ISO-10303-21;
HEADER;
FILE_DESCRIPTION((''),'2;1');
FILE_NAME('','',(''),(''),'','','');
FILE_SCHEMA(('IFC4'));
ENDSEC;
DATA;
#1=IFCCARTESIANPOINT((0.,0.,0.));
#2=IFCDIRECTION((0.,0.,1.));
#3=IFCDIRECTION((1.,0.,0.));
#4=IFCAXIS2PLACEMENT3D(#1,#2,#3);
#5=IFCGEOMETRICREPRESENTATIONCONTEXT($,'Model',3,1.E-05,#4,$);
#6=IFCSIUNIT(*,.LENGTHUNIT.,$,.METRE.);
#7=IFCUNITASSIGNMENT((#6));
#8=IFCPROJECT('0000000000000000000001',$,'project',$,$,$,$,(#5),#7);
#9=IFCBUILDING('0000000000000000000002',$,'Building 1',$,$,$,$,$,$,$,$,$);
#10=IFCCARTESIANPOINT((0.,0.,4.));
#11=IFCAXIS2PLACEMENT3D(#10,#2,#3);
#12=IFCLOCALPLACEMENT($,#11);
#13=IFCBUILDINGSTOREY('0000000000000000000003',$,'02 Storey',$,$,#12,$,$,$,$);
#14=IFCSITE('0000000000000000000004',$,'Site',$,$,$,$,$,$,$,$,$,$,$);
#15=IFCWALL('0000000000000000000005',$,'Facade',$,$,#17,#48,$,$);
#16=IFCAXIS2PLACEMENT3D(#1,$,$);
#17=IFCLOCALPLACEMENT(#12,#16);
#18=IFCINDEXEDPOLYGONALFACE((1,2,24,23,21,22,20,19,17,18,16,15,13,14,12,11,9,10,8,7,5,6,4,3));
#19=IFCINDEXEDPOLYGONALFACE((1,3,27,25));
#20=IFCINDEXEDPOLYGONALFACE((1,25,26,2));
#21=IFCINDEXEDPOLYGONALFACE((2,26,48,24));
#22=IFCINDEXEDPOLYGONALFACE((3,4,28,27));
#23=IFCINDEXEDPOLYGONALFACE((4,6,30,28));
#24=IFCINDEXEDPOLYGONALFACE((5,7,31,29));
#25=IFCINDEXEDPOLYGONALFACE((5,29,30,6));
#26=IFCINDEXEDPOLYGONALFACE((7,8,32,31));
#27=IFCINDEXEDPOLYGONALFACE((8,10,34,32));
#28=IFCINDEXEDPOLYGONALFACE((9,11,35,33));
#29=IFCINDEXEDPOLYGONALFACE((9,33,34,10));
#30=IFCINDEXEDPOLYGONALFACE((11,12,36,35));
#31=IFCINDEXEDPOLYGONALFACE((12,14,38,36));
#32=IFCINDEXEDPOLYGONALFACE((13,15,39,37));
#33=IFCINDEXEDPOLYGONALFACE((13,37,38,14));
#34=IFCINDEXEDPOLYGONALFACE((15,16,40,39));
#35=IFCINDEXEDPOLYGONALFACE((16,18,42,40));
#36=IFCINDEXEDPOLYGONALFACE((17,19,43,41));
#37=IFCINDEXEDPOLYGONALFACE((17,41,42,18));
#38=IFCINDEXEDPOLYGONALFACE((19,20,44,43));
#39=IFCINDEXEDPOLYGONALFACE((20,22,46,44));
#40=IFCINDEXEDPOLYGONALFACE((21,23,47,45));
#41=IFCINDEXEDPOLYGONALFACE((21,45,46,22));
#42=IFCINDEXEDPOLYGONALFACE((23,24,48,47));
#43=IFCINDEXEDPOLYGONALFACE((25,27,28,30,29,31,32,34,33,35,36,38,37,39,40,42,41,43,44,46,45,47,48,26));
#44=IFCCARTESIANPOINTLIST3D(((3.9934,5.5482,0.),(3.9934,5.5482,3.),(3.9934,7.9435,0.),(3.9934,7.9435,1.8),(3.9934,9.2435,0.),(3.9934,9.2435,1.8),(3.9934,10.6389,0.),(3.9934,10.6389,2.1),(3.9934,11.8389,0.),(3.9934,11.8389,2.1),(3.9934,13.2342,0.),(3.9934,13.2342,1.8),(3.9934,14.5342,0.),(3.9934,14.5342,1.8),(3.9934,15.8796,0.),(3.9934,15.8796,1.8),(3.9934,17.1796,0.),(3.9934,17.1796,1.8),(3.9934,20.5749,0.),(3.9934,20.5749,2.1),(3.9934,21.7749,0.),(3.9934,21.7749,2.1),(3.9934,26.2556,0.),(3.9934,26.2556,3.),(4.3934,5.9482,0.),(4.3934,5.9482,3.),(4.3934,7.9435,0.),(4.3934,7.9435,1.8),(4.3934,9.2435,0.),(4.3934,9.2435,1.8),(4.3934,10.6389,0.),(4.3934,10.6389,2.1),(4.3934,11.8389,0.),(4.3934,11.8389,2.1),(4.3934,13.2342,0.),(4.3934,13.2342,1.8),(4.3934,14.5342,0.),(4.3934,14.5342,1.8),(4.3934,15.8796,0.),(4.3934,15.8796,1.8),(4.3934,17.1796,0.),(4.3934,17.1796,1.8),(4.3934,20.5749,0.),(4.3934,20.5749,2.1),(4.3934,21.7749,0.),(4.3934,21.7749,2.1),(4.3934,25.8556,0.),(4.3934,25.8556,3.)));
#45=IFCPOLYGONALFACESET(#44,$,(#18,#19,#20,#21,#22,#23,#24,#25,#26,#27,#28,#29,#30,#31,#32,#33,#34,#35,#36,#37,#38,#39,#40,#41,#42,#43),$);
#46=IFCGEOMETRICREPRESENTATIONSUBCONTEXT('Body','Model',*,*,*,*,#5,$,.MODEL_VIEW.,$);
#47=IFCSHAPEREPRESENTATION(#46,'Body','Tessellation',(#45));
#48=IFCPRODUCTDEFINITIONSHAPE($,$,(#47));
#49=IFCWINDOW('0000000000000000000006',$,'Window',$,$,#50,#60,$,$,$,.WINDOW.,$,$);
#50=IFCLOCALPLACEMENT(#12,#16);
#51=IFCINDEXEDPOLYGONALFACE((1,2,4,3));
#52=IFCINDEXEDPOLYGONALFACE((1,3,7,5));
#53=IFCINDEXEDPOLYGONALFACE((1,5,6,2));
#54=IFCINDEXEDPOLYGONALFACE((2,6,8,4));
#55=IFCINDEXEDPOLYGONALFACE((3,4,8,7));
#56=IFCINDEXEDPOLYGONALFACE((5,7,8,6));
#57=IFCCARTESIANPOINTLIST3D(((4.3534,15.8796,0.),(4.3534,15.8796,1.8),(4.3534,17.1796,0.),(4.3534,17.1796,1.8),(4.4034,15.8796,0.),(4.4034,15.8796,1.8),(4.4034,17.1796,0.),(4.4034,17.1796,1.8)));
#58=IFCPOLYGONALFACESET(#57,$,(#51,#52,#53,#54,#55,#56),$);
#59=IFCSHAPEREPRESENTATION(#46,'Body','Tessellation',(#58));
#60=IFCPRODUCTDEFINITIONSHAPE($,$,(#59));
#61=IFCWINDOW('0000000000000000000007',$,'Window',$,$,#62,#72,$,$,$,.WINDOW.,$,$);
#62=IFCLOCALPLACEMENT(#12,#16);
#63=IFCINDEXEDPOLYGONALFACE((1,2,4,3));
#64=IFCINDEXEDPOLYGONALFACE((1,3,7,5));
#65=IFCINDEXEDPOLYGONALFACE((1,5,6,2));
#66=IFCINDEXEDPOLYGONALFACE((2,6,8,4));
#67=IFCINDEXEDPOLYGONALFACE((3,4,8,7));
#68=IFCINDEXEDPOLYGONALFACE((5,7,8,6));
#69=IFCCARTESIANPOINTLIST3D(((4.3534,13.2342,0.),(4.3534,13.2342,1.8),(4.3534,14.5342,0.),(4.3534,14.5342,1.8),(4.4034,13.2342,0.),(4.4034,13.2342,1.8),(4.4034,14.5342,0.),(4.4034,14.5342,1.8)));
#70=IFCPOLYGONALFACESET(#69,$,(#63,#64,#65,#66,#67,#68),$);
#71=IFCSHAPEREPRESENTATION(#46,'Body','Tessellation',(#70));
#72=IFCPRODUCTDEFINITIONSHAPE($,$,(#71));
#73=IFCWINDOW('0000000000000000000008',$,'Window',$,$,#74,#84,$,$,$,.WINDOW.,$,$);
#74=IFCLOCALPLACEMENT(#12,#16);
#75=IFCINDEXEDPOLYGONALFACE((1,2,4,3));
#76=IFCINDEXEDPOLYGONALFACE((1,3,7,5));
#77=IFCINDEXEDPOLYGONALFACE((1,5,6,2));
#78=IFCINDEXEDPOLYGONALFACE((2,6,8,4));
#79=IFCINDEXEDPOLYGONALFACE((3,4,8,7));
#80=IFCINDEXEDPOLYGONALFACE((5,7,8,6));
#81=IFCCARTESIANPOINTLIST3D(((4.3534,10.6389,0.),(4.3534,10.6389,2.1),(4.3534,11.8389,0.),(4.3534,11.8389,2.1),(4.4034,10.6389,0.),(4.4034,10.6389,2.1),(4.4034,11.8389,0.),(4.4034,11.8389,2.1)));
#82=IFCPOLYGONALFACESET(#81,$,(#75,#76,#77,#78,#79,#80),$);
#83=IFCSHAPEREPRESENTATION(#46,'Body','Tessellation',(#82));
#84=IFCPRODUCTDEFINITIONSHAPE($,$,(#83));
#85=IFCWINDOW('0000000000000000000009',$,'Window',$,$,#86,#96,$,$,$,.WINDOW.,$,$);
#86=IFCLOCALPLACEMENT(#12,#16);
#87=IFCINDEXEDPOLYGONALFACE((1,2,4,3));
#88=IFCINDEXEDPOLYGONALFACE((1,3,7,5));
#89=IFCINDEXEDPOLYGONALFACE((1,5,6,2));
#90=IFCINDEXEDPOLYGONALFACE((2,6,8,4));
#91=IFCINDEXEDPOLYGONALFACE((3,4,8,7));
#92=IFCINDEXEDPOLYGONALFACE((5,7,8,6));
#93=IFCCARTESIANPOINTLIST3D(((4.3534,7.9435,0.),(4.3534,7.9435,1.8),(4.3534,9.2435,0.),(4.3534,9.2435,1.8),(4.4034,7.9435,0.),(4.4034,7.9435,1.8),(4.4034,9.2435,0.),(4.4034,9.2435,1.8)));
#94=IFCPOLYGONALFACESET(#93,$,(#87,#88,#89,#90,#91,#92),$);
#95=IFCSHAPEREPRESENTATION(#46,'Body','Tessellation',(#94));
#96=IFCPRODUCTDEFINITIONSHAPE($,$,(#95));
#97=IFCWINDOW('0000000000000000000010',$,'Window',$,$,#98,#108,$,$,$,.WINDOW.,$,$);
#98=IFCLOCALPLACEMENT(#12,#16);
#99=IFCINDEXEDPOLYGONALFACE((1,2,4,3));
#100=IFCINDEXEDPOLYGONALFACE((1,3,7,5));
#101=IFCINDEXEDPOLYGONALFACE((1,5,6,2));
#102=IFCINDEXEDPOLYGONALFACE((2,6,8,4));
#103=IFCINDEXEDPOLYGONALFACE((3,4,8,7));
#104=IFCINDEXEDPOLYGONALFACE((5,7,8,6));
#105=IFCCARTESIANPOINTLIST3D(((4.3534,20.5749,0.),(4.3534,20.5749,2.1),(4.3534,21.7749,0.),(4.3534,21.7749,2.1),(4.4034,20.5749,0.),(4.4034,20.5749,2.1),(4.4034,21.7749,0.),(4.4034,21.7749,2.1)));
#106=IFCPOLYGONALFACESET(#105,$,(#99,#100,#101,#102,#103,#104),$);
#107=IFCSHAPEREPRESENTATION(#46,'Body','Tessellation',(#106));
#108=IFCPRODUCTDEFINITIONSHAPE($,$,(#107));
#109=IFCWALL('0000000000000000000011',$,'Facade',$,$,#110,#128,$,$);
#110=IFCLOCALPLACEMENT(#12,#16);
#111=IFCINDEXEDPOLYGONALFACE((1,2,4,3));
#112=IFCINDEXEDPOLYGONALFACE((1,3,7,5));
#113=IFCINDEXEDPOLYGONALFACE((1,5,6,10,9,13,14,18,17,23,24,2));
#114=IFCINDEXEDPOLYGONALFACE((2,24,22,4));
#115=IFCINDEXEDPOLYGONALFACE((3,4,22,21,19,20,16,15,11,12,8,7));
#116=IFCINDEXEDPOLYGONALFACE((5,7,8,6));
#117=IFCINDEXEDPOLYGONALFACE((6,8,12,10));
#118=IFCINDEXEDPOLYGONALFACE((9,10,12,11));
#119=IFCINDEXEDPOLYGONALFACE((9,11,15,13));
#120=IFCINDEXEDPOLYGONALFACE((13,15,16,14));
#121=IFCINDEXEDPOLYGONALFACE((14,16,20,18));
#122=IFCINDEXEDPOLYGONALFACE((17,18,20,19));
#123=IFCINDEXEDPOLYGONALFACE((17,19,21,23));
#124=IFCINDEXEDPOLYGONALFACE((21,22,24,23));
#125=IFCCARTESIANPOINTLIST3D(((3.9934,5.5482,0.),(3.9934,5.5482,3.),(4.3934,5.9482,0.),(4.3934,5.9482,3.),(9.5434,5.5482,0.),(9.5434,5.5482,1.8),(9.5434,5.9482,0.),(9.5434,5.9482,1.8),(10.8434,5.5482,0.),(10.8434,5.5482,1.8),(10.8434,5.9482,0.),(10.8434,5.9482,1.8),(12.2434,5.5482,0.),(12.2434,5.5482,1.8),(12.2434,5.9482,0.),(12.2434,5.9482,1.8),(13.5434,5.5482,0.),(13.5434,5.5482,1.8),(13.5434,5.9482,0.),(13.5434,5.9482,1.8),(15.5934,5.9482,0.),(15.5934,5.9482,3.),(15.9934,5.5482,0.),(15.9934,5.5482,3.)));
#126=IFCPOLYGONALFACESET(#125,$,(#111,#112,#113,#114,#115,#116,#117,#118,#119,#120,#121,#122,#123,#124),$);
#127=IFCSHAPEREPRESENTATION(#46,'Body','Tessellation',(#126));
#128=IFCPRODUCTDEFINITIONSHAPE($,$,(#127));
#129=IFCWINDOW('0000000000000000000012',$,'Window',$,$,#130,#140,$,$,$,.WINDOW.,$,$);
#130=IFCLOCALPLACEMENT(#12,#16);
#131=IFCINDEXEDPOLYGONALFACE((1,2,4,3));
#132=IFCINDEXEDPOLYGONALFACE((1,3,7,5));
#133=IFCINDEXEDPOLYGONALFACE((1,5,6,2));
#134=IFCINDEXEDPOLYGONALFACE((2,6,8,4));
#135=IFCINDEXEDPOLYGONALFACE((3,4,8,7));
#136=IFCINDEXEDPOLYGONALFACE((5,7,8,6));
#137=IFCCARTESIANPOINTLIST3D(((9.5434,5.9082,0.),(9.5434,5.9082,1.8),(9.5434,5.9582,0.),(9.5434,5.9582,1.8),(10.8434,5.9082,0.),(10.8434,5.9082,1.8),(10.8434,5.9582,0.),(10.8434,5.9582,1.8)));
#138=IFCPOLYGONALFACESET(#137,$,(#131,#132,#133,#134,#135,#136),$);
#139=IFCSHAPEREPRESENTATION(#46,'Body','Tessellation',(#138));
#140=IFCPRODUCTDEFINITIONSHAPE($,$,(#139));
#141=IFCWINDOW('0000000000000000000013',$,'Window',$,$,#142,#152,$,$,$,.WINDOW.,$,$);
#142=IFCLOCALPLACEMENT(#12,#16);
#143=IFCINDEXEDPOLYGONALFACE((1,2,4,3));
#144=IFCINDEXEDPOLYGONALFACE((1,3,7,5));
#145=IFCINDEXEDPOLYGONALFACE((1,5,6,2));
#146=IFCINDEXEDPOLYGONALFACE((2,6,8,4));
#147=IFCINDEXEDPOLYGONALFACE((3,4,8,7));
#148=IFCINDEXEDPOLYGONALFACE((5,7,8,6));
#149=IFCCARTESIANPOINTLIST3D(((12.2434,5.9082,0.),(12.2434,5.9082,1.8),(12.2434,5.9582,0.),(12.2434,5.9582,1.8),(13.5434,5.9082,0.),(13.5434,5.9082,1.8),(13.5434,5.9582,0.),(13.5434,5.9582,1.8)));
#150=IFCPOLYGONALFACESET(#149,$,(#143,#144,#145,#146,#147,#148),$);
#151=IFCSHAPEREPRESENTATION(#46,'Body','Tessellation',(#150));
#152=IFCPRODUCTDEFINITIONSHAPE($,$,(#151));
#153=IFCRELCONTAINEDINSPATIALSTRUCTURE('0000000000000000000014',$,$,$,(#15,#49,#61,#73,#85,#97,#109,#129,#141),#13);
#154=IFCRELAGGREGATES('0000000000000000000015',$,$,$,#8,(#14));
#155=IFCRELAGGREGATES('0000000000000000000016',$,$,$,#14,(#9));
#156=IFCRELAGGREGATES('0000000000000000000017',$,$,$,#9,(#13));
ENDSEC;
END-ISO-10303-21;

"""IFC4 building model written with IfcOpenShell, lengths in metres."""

from ifc_helpers import new_model, si_unit, frame, origin_with_axes, place, context, subcontext, project, spatial, line, indexed_curve, outline, extrude, element, fill, save


model = new_model("IFC4")

# Units and contexts
model_context = context("Model", 3, precision=1e-05, world=origin_with_axes())
body_context = subcontext(model_context, "Body", "Model", "MODEL_VIEW")
ifc_project = project(units=[si_unit("LENGTHUNIT", "METRE")], contexts=[model_context])

# Site, building, storey
site = spatial("IfcSite", under=ifc_project, Name="Site")
building = spatial("IfcBuilding", under=site, Name="Building 1")
storey_placement = place(None, frame((0.0, 0.0, 4.0), z_axis=(0.0, 0.0, 1.0), x_axis=(1.0, 0.0, 0.0)))
storey = spatial("IfcBuildingStorey", under=building, at=storey_placement, Name="02 Storey")

# Walls, openings, windows
wall_1_placement = place(storey_placement, origin_with_axes())
wall_1 = element("IfcWall", 1, at=wall_1_placement, inside=storey, Name="Facade", context=body_context, shape_type="SweptSolid", body=[
    extrude(outline(indexed_curve([(4.3934, 25.8556), (4.3934, 5.9482), (3.9934, 5.5482), (3.9934, 26.2556)], segments=[line(1, 2), line(2, 3), line(3, 4)])), origin_with_axes(), (0.0, 0.0, 1.0), 3.0),
])
opening_1_placement = place(wall_1_placement, origin_with_axes())
opening_1 = element("IfcOpeningElement", 2, at=opening_1_placement, cuts=wall_1, context=body_context, shape_type="SweptSolid", body=[
    extrude(outline(indexed_curve([(3.9534, 17.1796), (4.4534, 17.1796), (4.4534, 15.8796), (3.9534, 15.8796)], segments=[line(1, 2), line(2, 3), line(3, 4)])), origin_with_axes(), (0.0, 0.0, 1.0), 1.8),
])
opening_2_placement = place(wall_1_placement, origin_with_axes())
opening_2 = element("IfcOpeningElement", 3, at=opening_2_placement, cuts=wall_1, context=body_context, shape_type="SweptSolid", body=[
    extrude(outline(indexed_curve([(3.9534, 14.5342), (4.4534, 14.5342), (4.4534, 13.2342), (3.9534, 13.2342)], segments=[line(1, 2), line(2, 3), line(3, 4)])), origin_with_axes(), (0.0, 0.0, 1.0), 1.8),
])
opening_3_placement = place(wall_1_placement, origin_with_axes())
opening_3 = element("IfcOpeningElement", 4, at=opening_3_placement, cuts=wall_1, context=body_context, shape_type="SweptSolid", body=[
    extrude(outline(indexed_curve([(3.9534, 11.8389), (4.4534, 11.8389), (4.4534, 10.6389), (3.9534, 10.6389)], segments=[line(1, 2), line(2, 3), line(3, 4)])), origin_with_axes(), (0.0, 0.0, 1.0), 2.1),
])
opening_4_placement = place(wall_1_placement, origin_with_axes())
opening_4 = element("IfcOpeningElement", 5, at=opening_4_placement, cuts=wall_1, context=body_context, shape_type="SweptSolid", body=[
    extrude(outline(indexed_curve([(3.9534, 9.2435), (4.4534, 9.2435), (4.4534, 7.9435), (3.9534, 7.9435)], segments=[line(1, 2), line(2, 3), line(3, 4)])), origin_with_axes(), (0.0, 0.0, 1.0), 1.8),
])
opening_5_placement = place(wall_1_placement, origin_with_axes())
opening_5 = element("IfcOpeningElement", 6, at=opening_5_placement, cuts=wall_1, context=body_context, shape_type="SweptSolid", body=[
    extrude(outline(indexed_curve([(3.9534, 21.7749), (4.4534, 21.7749), (4.4534, 20.5749), (3.9534, 20.5749)], segments=[line(1, 2), line(2, 3), line(3, 4)])), origin_with_axes(), (0.0, 0.0, 1.0), 2.1),
])
window_1_placement = place(storey_placement, origin_with_axes())
window_1 = element("IfcWindow", 7, at=window_1_placement, inside=storey, Name="Window", PredefinedType="WINDOW", context=body_context, shape_type="SweptSolid", body=[
    extrude(outline(indexed_curve([(4.3534, 17.1796), (4.4034, 17.1796), (4.4034, 15.8796), (4.3534, 15.8796)], segments=[line(1, 2), line(2, 3), line(3, 4)])), origin_with_axes(), (0.0, 0.0, 1.0), 1.8),
])
fill(opening_1, window_1)
window_2_placement = place(storey_placement, origin_with_axes())
window_2 = element("IfcWindow", 8, at=window_2_placement, inside=storey, Name="Window", PredefinedType="WINDOW", context=body_context, shape_type="SweptSolid", body=[
    extrude(outline(indexed_curve([(4.3534, 14.5342), (4.4034, 14.5342), (4.4034, 13.2342), (4.3534, 13.2342)], segments=[line(1, 2), line(2, 3), line(3, 4)])), origin_with_axes(), (0.0, 0.0, 1.0), 1.8),
])
fill(opening_2, window_2)
window_3_placement = place(storey_placement, origin_with_axes())
window_3 = element("IfcWindow", 9, at=window_3_placement, inside=storey, Name="Window", PredefinedType="WINDOW", context=body_context, shape_type="SweptSolid", body=[
    extrude(outline(indexed_curve([(4.3534, 11.8389), (4.4034, 11.8389), (4.4034, 10.6389), (4.3534, 10.6389)], segments=[line(1, 2), line(2, 3), line(3, 4)])), origin_with_axes(), (0.0, 0.0, 1.0), 2.1),
])
fill(opening_3, window_3)
window_4_placement = place(storey_placement, origin_with_axes())
window_4 = element("IfcWindow", 10, at=window_4_placement, inside=storey, Name="Window", PredefinedType="WINDOW", context=body_context, shape_type="SweptSolid", body=[
    extrude(outline(indexed_curve([(4.3534, 9.2435), (4.4034, 9.2435), (4.4034, 7.9435), (4.3534, 7.9435)], segments=[line(1, 2), line(2, 3), line(3, 4)])), origin_with_axes(), (0.0, 0.0, 1.0), 1.8),
])
fill(opening_4, window_4)
window_5_placement = place(storey_placement, origin_with_axes())
window_5 = element("IfcWindow", 11, at=window_5_placement, inside=storey, Name="Window", PredefinedType="WINDOW", context=body_context, shape_type="SweptSolid", body=[
    extrude(outline(indexed_curve([(4.3534, 21.7749), (4.4034, 21.7749), (4.4034, 20.5749), (4.3534, 20.5749)], segments=[line(1, 2), line(2, 3), line(3, 4)])), origin_with_axes(), (0.0, 0.0, 1.0), 2.1),
])
fill(opening_5, window_5)
wall_2_placement = place(storey_placement, origin_with_axes())
wall_2 = element("IfcWall", 12, at=wall_2_placement, inside=storey, Name="Facade", context=body_context, shape_type="SweptSolid", body=[
    extrude(outline(indexed_curve([(4.3934, 5.9482), (15.5934, 5.9482), (15.9934, 5.5482), (3.9934, 5.5482)], segments=[line(1, 2), line(2, 3), line(3, 4)])), origin_with_axes(), (0.0, 0.0, 1.0), 3.0),
])
opening_6_placement = place(wall_2_placement, origin_with_axes())
opening_6 = element("IfcOpeningElement", 13, at=opening_6_placement, cuts=wall_2, context=body_context, shape_type="SweptSolid", body=[
    extrude(outline(indexed_curve([(9.5434, 5.5082), (9.5434, 6.0082), (10.8434, 6.0082), (10.8434, 5.5082)], segments=[line(1, 2), line(2, 3), line(3, 4)])), origin_with_axes(), (0.0, 0.0, 1.0), 1.8),
])
opening_7_placement = place(wall_2_placement, origin_with_axes())
opening_7 = element("IfcOpeningElement", 14, at=opening_7_placement, cuts=wall_2, context=body_context, shape_type="SweptSolid", body=[
    extrude(outline(indexed_curve([(12.2434, 5.5082), (12.2434, 6.0082), (13.5434, 6.0082), (13.5434, 5.5082)], segments=[line(1, 2), line(2, 3), line(3, 4)])), origin_with_axes(), (0.0, 0.0, 1.0), 1.8),
])
window_6_placement = place(storey_placement, origin_with_axes())
window_6 = element("IfcWindow", 15, at=window_6_placement, inside=storey, Name="Window", PredefinedType="WINDOW", context=body_context, shape_type="SweptSolid", body=[
    extrude(outline(indexed_curve([(9.5434, 5.9082), (9.5434, 5.9582), (10.8434, 5.9582), (10.8434, 5.9082)], segments=[line(1, 2), line(2, 3), line(3, 4)])), origin_with_axes(), (0.0, 0.0, 1.0), 1.8),
])
fill(opening_6, window_6)
window_7_placement = place(storey_placement, origin_with_axes())
window_7 = element("IfcWindow", 16, at=window_7_placement, inside=storey, Name="Window", PredefinedType="WINDOW", context=body_context, shape_type="SweptSolid", body=[
    extrude(outline(indexed_curve([(12.2434, 5.9082), (12.2434, 5.9582), (13.5434, 5.9582), (13.5434, 5.9082)], segments=[line(1, 2), line(2, 3), line(3, 4)])), origin_with_axes(), (0.0, 0.0, 1.0), 1.8),
])
fill(opening_7, window_7)

save(model, "model.ifc")
